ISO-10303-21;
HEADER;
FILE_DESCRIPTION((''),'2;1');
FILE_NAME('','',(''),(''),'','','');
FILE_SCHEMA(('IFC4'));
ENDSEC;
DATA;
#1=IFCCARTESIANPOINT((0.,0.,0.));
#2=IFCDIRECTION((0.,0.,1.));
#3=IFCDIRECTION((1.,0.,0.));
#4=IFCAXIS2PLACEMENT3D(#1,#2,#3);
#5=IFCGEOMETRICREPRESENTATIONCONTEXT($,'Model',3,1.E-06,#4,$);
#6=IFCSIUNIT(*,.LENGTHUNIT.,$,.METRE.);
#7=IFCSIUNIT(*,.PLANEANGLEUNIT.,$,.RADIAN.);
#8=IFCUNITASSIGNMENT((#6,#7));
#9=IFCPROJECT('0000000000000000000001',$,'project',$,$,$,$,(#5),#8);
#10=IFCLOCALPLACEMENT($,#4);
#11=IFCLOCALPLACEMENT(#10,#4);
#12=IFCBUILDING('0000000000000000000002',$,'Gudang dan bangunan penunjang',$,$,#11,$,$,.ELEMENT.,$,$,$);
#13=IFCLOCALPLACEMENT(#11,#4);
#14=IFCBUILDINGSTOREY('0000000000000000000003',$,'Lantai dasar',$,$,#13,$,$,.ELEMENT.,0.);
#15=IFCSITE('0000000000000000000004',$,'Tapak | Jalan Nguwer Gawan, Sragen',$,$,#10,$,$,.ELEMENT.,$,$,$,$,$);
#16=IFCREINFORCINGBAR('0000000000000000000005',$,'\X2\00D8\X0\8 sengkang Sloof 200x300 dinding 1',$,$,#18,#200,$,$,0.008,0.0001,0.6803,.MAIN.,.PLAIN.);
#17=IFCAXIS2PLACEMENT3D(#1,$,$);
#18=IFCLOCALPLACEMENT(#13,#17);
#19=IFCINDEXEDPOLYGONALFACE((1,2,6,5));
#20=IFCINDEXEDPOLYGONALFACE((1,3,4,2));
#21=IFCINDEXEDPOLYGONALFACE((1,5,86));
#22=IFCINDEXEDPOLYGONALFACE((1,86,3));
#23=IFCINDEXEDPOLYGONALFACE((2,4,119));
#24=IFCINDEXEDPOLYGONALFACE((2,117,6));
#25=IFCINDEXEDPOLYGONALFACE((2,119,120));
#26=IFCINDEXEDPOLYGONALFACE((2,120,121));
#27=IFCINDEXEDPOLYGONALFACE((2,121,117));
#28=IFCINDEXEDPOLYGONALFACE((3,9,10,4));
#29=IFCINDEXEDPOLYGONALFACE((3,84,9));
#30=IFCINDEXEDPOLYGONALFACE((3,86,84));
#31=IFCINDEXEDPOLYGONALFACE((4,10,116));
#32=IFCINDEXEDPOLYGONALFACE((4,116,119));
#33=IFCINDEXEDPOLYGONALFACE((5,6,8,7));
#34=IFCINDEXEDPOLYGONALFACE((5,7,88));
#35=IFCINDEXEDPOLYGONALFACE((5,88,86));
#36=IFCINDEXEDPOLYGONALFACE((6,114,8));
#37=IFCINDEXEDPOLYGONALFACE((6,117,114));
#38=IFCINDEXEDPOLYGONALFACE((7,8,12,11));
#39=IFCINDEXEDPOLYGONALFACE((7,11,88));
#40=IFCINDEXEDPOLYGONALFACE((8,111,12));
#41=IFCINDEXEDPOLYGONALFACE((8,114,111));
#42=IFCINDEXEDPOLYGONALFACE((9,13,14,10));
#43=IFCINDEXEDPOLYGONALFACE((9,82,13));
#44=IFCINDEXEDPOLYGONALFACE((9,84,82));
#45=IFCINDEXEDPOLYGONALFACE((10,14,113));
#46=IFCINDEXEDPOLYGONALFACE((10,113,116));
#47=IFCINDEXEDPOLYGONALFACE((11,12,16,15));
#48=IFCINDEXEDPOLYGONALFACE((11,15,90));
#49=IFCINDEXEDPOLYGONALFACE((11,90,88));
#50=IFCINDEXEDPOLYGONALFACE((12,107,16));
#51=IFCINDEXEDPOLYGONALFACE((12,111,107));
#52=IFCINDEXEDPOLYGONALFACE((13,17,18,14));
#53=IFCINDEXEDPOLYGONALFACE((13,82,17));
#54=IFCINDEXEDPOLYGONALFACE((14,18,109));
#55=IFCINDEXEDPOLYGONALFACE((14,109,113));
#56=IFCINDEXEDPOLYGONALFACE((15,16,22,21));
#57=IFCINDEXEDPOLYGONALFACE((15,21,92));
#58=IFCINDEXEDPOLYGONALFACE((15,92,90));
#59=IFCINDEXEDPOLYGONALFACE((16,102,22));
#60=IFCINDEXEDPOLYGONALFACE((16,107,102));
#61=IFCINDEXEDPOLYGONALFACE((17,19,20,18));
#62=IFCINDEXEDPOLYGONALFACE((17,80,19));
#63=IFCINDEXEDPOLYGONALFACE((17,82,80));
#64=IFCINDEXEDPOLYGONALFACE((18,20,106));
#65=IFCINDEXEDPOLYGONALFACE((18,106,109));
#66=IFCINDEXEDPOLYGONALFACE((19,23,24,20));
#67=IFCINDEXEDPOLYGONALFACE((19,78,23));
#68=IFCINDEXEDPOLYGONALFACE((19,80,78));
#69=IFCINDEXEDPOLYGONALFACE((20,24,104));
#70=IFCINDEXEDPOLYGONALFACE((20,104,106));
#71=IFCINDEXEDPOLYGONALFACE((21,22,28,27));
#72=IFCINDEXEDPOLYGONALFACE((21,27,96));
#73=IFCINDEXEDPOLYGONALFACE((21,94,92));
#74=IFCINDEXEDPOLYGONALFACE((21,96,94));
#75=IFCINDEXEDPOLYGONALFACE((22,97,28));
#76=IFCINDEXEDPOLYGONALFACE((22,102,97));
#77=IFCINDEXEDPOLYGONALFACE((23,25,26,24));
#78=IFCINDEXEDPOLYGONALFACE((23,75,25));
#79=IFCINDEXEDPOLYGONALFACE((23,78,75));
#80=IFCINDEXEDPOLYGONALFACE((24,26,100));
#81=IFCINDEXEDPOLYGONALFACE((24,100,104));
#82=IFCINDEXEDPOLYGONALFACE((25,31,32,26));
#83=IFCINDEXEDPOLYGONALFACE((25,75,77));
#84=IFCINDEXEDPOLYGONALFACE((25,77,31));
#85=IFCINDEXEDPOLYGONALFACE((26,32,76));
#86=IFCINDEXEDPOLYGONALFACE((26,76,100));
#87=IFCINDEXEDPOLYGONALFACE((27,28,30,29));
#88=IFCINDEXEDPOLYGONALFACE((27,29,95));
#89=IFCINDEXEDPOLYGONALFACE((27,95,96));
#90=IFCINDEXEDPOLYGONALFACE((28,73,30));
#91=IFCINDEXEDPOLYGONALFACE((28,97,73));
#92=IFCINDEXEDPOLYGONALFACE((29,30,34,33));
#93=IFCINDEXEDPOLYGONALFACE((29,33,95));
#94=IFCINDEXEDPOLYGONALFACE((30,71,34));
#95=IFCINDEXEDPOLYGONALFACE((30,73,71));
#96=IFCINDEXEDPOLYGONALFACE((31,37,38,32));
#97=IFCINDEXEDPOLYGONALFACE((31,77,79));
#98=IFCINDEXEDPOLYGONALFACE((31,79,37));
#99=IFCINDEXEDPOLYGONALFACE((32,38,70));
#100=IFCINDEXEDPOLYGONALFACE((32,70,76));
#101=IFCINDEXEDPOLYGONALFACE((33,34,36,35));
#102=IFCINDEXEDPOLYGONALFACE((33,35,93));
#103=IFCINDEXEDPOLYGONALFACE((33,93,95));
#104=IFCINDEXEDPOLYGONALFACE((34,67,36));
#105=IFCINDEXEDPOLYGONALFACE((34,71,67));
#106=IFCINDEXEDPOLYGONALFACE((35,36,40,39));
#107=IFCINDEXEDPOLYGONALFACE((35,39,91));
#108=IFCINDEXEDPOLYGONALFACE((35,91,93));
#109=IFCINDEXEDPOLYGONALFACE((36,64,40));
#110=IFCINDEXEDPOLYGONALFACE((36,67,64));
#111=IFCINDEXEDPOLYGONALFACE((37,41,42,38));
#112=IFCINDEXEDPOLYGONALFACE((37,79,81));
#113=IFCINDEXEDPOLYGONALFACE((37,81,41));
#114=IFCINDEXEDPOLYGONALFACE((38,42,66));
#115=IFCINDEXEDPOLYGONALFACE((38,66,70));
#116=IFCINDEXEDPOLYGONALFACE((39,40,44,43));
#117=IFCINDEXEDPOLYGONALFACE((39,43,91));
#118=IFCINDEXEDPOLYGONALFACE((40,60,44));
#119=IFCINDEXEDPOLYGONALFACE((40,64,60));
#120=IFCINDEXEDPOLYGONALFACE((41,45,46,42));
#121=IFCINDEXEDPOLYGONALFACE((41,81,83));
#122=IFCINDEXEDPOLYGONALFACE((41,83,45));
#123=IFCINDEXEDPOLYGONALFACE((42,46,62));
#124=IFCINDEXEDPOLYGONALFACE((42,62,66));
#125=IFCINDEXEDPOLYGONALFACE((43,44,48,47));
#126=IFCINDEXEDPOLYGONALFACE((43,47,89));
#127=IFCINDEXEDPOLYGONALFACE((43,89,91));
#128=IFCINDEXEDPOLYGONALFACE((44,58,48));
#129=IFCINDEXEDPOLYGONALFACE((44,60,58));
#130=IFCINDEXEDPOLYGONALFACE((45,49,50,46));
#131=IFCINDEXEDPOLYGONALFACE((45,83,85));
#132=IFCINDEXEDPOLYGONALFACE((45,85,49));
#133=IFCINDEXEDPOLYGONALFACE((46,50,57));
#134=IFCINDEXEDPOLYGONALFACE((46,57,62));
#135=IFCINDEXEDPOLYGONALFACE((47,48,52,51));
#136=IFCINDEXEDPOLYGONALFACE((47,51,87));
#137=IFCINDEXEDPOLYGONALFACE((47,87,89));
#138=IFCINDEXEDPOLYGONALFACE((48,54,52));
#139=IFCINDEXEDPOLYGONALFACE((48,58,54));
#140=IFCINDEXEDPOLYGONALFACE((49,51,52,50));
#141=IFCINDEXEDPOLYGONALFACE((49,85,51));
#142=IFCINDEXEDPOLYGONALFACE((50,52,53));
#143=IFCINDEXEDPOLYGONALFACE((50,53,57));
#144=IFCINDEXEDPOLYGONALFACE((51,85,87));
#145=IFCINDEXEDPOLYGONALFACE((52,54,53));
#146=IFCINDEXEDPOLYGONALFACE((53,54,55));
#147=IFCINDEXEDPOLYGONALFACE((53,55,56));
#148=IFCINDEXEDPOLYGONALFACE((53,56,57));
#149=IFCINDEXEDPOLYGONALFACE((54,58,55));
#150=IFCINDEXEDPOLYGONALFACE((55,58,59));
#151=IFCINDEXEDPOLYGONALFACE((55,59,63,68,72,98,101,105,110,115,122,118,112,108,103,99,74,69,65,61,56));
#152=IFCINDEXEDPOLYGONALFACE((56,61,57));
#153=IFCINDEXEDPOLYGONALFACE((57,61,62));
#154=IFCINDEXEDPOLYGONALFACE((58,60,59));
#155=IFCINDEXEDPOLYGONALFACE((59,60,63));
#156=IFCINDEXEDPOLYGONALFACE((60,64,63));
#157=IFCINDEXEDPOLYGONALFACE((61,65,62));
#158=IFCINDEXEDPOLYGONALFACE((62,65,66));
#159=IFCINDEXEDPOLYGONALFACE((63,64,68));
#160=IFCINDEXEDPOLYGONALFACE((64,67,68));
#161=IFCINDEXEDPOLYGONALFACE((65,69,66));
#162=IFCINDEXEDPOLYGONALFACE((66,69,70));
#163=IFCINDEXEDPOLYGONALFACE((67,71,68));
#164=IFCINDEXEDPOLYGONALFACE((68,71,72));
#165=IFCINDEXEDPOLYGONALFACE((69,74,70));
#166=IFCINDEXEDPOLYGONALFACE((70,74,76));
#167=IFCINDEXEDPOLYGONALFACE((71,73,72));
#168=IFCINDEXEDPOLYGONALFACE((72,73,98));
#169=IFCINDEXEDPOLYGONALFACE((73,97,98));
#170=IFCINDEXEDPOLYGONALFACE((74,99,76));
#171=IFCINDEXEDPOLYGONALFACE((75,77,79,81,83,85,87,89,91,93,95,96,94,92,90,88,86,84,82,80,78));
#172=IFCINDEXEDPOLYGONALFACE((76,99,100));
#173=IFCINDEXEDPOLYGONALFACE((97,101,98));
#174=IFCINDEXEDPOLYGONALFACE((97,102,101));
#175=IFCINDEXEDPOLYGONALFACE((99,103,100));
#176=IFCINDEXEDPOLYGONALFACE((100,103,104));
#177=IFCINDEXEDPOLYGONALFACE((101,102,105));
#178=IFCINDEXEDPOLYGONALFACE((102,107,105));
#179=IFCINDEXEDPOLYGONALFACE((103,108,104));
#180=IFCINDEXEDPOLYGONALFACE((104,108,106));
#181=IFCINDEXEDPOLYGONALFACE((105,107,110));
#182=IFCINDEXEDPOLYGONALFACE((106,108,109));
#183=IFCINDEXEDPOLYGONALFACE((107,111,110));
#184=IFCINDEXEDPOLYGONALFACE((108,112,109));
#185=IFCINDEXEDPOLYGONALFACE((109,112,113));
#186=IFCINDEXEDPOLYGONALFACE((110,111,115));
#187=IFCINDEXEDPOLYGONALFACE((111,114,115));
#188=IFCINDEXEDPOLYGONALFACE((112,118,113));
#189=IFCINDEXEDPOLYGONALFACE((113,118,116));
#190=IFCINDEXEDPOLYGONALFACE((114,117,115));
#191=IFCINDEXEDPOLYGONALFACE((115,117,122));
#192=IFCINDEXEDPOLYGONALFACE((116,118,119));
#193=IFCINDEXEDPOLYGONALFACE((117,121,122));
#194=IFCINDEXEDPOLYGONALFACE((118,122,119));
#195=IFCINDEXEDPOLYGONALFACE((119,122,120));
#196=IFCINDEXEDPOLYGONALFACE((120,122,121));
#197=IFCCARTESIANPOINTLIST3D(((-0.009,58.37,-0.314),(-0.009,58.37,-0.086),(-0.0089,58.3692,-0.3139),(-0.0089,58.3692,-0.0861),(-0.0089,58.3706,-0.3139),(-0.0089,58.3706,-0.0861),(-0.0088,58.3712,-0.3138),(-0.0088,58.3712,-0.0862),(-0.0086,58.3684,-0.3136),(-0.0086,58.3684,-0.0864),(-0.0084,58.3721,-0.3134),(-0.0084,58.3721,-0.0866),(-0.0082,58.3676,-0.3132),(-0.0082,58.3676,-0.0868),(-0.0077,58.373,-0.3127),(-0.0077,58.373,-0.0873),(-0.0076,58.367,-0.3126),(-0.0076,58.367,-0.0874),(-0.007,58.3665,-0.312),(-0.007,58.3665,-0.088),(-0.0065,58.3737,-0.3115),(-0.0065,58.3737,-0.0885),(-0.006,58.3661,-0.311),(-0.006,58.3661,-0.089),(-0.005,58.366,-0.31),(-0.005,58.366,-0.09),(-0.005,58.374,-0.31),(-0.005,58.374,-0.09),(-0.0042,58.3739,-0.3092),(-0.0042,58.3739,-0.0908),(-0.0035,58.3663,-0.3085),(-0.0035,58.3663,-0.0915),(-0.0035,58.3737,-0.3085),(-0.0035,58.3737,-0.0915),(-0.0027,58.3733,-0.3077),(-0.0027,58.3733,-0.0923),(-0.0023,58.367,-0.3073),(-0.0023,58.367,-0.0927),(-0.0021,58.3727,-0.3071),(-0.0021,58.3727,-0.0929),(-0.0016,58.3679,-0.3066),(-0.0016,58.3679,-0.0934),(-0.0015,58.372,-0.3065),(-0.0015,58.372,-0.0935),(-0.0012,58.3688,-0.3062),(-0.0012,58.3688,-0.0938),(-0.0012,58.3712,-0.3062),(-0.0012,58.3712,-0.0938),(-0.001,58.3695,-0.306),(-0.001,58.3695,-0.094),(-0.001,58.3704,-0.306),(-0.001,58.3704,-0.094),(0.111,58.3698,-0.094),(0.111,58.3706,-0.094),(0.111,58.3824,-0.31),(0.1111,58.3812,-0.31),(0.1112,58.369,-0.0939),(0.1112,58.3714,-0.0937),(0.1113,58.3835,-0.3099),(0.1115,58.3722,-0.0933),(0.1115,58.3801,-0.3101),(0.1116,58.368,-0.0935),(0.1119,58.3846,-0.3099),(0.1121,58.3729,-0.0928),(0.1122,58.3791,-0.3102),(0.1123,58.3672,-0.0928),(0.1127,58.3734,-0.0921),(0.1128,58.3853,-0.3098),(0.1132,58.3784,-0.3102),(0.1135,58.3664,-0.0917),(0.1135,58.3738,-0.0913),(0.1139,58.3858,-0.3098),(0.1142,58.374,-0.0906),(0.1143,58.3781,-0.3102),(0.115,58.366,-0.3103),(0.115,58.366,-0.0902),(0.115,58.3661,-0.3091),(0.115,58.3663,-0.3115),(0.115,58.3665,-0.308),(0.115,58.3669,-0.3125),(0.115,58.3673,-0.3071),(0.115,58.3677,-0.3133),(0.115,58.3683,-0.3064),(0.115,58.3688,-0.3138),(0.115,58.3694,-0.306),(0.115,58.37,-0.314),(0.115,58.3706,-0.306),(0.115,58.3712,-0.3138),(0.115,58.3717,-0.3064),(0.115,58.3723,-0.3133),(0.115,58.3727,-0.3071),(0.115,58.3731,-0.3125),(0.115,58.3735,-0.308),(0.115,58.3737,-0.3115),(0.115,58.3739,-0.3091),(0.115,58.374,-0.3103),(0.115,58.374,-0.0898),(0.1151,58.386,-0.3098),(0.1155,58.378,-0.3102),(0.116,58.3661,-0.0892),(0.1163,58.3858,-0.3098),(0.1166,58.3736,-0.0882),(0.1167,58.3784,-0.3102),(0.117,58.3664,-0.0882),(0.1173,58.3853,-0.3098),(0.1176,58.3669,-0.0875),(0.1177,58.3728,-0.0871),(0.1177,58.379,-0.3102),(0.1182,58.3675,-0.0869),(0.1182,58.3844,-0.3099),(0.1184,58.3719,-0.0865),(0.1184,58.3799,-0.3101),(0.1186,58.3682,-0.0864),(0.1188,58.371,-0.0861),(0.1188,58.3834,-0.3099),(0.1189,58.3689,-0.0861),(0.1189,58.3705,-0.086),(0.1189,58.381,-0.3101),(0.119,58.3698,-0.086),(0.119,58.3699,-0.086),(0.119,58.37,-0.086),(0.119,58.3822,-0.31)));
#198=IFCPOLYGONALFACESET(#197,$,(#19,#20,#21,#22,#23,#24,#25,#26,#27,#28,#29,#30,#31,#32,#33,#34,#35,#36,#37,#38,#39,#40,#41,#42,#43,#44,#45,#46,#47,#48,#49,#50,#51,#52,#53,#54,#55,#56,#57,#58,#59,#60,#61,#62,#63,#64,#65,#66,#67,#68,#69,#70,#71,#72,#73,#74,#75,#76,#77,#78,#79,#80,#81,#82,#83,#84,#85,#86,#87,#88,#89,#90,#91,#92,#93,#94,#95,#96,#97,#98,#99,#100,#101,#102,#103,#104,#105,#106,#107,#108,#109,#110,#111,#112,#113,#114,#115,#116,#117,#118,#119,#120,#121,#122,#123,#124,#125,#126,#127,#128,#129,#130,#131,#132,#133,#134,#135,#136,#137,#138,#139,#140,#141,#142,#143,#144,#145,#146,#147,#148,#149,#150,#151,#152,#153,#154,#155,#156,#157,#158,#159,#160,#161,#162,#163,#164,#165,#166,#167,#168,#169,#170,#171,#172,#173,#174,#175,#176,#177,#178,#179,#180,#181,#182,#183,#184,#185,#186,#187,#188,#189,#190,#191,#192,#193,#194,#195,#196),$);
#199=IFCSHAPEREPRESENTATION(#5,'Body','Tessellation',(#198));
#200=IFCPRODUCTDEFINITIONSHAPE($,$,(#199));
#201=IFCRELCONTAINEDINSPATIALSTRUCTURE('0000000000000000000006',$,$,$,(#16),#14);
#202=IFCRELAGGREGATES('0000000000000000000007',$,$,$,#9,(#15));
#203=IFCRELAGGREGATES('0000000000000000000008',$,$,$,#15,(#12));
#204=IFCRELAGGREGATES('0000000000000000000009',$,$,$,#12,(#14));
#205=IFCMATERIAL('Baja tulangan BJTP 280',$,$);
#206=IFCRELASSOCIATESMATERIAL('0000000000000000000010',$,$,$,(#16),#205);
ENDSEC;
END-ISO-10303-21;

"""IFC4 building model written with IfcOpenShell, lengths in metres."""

from ifc_helpers import new_model, entity, si_unit, origin_with_axes, place, context, project, spatial, material, element, save


model = new_model("IFC4")

# Units and contexts
model_context = context("Model", 3, precision=1e-06, world=origin_with_axes())
ifc_project = project(units=[si_unit("LENGTHUNIT", "METRE"), si_unit("PLANEANGLEUNIT", "RADIAN")], contexts=[model_context])

# Site, building, storey
site_placement = place(None, origin_with_axes())
site = spatial("IfcSite", under=ifc_project, at=site_placement, Name="Tapak | Jalan Nguwer Gawan, Sragen", CompositionType="ELEMENT")
building_placement = place(site_placement, origin_with_axes())
building = spatial("IfcBuilding", under=site, at=building_placement, Name="Gudang dan bangunan penunjang", CompositionType="ELEMENT")
storey_placement = place(building_placement, origin_with_axes())
storey = spatial("IfcBuildingStorey", under=building, at=storey_placement, Name="Lantai dasar", CompositionType="ELEMENT", Elevation=0.0)

# Shared definitions
placement = place(None, origin_with_axes())

# Reinforcing bar
ifc_material_1 = material(Name="Baja tulangan BJTP 280")
element("IfcReinforcingBar", 1, at=placement, inside=storey, material=ifc_material_1, Name="Ø8 sengkang Sloof 200x300 dinding 1", BarLength=0.6803, BarSurface="PLAIN", CrossSectionArea=0.0001, NominalDiameter=0.008, PredefinedType="MAIN", context=model_context, shape_type="AdvancedSweptSolid", body=[
    entity("IfcSweptDiskSolid", entity("IfcPolyline", [entity("IfcCartesianPoint", [0.115, 58.37, -0.31]), entity("IfcCartesianPoint", [-0.005, 58.37, -0.31]), entity("IfcCartesianPoint", [-0.005, 58.37, -0.09]), entity("IfcCartesianPoint", [0.115, 58.37, -0.09]), entity("IfcCartesianPoint", [0.115, 58.382, -0.31])]), 0.004),
])

save(model, "model.ifc")
